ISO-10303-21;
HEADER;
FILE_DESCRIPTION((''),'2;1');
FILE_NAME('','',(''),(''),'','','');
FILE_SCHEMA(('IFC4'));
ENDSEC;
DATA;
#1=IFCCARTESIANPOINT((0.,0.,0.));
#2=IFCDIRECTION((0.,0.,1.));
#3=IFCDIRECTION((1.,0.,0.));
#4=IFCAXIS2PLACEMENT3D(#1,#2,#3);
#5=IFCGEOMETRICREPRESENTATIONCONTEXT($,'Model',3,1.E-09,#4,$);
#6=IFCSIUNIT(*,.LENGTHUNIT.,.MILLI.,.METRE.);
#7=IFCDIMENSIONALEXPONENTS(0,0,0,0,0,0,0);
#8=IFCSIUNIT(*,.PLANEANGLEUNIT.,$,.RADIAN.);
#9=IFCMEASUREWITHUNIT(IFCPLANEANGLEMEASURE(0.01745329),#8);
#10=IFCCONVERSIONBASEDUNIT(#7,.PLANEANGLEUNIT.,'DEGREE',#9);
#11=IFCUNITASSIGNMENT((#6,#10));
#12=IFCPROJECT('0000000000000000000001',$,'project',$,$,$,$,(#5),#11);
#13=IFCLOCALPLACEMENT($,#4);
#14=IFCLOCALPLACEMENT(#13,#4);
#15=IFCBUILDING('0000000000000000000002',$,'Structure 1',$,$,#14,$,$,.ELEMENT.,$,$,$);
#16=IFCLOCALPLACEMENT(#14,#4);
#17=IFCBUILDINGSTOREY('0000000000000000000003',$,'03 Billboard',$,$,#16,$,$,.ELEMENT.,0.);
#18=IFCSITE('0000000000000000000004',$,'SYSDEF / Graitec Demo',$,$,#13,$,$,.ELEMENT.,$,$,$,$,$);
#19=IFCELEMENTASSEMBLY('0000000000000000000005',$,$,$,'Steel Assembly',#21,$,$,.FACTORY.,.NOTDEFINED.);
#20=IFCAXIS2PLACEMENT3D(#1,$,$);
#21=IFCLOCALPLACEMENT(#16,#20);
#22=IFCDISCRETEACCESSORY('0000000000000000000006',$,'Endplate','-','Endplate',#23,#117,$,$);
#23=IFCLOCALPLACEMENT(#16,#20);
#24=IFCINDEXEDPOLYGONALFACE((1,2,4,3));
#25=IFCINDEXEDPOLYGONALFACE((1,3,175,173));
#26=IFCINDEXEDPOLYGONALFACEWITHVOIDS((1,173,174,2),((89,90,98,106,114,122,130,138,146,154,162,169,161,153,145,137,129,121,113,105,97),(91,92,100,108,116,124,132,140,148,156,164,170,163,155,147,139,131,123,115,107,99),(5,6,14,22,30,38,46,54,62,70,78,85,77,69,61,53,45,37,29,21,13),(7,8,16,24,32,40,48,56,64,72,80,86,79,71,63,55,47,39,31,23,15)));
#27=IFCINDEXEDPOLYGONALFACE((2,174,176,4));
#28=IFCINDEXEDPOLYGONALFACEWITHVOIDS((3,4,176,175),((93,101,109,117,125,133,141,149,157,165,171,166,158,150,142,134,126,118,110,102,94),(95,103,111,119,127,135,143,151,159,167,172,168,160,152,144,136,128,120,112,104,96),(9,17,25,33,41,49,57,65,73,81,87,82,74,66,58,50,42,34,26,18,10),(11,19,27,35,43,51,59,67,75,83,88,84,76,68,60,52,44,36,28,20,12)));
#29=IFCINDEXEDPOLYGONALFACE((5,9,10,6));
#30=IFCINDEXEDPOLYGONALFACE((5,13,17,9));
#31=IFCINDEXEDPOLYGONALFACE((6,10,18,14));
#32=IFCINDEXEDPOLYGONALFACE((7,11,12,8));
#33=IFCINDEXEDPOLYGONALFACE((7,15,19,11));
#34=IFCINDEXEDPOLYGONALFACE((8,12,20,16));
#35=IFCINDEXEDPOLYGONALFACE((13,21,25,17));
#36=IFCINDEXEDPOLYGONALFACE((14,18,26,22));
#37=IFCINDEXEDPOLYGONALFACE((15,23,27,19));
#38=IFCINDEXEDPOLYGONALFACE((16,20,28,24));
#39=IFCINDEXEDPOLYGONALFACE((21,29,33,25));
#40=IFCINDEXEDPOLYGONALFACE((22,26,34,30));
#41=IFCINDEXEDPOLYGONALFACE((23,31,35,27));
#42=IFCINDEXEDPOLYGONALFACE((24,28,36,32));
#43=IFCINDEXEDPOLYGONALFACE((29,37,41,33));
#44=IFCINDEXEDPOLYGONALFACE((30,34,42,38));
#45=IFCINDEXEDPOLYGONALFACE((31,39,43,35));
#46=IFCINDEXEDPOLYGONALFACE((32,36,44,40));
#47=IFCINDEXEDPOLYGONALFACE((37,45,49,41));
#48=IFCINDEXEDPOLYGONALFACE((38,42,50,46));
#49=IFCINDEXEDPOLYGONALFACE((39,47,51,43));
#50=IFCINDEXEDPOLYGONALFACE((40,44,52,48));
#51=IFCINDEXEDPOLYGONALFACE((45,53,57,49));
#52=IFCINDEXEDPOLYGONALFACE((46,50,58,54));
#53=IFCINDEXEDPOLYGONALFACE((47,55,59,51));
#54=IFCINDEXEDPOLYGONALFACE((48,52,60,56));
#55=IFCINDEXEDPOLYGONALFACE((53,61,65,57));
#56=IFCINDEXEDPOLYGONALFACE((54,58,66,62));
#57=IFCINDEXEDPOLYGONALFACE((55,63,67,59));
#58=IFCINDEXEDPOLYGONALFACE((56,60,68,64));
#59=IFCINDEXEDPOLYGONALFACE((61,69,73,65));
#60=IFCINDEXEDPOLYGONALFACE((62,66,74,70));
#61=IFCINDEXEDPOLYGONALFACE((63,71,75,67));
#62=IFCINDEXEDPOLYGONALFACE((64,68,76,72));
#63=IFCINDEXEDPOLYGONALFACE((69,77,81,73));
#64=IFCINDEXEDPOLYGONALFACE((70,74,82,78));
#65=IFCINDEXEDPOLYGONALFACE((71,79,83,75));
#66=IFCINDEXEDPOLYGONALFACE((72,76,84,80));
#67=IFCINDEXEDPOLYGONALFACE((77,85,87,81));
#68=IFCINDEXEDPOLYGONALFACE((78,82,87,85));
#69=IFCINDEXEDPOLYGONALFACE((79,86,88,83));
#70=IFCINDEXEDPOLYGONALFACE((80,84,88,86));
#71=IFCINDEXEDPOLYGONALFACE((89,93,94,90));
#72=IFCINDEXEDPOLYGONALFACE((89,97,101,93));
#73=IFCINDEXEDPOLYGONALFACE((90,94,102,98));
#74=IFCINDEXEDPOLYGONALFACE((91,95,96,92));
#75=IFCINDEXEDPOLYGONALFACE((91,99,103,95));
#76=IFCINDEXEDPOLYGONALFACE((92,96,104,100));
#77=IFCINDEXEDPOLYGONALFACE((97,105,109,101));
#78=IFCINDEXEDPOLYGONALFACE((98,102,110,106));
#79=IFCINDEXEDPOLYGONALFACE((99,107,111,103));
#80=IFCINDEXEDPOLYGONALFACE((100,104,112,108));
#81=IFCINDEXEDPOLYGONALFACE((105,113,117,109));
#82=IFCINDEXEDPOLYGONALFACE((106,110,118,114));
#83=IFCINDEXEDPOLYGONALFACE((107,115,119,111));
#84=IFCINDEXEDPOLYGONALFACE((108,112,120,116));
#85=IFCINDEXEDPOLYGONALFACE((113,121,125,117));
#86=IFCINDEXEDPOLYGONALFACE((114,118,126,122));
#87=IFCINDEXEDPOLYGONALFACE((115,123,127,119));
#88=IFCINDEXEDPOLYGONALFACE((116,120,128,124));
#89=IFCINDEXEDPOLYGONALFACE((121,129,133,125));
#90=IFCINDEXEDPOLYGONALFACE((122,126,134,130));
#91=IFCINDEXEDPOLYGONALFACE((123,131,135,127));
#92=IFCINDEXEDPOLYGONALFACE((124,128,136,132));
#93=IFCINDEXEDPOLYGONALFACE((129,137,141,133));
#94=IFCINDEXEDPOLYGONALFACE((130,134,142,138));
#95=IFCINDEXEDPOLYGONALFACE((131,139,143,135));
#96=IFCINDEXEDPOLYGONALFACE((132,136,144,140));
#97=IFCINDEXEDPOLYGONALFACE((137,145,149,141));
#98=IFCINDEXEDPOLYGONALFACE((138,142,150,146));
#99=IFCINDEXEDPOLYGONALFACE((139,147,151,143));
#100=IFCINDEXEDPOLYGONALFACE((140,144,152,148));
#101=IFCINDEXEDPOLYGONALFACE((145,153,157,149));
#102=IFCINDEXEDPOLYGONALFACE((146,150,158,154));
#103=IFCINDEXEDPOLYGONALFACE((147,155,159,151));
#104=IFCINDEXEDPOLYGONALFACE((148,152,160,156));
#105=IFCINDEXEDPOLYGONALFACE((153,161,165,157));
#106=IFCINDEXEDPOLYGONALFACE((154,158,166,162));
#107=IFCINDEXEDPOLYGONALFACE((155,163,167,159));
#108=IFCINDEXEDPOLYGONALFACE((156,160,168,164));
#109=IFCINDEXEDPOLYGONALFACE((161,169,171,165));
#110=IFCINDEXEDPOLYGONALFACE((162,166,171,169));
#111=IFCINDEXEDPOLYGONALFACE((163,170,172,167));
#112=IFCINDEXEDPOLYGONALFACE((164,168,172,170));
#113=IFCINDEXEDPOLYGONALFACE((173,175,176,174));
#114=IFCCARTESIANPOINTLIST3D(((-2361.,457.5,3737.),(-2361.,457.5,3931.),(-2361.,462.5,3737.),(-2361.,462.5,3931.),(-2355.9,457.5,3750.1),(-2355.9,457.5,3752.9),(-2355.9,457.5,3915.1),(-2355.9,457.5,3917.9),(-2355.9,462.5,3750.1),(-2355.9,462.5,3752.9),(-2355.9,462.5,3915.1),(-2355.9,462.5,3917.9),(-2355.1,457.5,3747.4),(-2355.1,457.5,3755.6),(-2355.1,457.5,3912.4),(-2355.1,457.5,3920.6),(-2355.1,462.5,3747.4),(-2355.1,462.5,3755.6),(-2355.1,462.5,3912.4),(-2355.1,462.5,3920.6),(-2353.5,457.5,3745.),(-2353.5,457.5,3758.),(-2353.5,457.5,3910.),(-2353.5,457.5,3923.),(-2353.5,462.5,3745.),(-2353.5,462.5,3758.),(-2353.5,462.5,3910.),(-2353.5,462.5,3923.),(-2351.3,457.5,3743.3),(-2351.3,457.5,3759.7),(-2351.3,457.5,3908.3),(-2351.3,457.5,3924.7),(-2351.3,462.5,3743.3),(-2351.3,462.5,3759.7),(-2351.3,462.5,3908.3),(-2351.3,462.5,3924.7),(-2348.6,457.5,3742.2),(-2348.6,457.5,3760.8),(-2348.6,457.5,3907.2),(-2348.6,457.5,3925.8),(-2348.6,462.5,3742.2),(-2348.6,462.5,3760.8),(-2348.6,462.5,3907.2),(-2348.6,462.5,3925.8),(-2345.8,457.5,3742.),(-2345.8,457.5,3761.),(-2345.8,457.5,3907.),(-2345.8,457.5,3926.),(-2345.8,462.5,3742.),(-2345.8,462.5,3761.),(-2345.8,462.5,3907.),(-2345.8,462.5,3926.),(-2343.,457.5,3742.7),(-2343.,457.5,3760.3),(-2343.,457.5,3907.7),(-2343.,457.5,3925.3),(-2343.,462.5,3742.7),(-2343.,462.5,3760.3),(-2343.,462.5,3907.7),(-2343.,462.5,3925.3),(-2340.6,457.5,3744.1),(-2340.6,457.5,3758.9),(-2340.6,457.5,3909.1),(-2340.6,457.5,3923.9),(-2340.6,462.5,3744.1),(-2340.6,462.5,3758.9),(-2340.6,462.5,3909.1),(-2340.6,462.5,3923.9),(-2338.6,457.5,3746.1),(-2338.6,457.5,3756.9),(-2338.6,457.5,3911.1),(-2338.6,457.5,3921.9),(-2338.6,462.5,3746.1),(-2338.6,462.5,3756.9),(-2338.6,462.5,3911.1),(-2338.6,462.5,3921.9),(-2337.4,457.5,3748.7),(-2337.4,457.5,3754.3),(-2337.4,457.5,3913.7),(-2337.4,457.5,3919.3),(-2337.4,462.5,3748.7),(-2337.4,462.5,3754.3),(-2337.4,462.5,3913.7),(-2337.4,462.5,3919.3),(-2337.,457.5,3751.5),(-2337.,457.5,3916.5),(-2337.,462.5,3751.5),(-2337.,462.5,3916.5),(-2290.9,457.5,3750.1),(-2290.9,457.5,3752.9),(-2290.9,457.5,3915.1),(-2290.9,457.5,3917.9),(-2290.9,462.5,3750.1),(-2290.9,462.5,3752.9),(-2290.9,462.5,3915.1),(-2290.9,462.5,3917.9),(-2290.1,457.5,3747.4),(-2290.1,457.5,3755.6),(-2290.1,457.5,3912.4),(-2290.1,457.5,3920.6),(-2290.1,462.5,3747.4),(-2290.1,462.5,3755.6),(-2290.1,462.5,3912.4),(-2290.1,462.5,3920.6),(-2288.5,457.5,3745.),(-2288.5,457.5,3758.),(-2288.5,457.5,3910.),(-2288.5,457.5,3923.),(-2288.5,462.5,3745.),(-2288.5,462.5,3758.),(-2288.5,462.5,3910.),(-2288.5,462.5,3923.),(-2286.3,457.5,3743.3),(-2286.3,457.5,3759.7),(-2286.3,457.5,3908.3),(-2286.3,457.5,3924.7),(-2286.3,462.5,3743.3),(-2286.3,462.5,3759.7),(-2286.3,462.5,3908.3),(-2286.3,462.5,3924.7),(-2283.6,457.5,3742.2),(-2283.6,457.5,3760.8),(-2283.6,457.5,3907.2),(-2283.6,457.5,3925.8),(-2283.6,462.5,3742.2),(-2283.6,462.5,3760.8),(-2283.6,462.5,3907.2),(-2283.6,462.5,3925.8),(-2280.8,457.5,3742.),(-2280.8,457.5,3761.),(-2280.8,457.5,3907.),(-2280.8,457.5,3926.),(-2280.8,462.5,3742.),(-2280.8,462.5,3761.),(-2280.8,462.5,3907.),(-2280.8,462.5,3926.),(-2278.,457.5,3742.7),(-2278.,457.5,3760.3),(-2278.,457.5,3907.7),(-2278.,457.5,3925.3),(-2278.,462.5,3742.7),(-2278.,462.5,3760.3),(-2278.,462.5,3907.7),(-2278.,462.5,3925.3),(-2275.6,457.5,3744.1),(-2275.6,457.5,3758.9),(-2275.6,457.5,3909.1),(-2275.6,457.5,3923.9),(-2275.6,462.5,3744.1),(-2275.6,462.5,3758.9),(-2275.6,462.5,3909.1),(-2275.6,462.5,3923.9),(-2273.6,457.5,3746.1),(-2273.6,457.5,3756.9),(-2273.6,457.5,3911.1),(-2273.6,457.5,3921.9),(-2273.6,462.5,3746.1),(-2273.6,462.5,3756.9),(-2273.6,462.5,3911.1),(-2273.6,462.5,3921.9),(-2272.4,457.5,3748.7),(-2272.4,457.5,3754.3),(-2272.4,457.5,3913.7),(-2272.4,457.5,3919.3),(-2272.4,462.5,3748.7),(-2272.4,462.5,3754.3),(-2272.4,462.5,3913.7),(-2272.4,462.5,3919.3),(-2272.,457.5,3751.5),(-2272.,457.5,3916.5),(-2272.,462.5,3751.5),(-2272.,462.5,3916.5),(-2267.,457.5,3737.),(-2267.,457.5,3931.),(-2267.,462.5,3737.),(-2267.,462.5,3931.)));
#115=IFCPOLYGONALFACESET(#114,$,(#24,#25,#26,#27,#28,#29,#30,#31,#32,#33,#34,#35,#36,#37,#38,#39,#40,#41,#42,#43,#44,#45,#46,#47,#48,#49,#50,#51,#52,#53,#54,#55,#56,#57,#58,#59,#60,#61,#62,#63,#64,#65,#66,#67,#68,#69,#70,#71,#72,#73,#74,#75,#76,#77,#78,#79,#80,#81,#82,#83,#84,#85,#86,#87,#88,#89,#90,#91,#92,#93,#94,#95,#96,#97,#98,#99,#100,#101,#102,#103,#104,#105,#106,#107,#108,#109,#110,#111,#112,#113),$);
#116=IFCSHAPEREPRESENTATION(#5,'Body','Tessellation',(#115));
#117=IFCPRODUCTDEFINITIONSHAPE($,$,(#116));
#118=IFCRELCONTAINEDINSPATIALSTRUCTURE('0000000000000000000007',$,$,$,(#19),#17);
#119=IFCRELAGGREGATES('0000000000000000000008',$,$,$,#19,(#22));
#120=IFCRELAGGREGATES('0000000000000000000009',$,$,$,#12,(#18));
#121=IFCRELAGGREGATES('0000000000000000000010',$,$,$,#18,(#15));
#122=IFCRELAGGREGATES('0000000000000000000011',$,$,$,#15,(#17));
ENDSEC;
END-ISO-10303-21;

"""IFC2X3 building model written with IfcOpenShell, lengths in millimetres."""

from ifc_helpers import new_model, entity, si_unit, converted_unit, frame, frame_2d, origin, origin_with_axes, place, context, project, spatial, polyline, circle, outline, extrude, element, aggregate, save


model = new_model("IFC2X3")

# Units and contexts
model_context = context("Model", 3, precision=1e-09, world=origin_with_axes())
ifc_project = project(units=[si_unit("LENGTHUNIT", "METRE", prefix="MILLI"), converted_unit("PLANEANGLEUNIT", "DEGREE", entity("IfcPlaneAngleMeasure", 0.01745329), si_unit("PLANEANGLEUNIT", "RADIAN"), dimensions=[0, 0, 0, 0, 0, 0, 0])], contexts=[model_context])

# Site, building, storey
site_placement = place(None, origin_with_axes())
site = spatial("IfcSite", under=ifc_project, at=site_placement, Name="SYSDEF / Graitec Demo", CompositionType="ELEMENT")
building_placement = place(site_placement, origin_with_axes())
building = spatial("IfcBuilding", under=site, at=building_placement, Name="Structure 1", CompositionType="ELEMENT")
storey_placement = place(building_placement, origin_with_axes())
storey = spatial("IfcBuildingStorey", under=building, at=storey_placement, Name="03 Billboard", CompositionType="ELEMENT", Elevation=0.0)

# Element assembly
assembly_1_placement = place(None, frame((-4406.3, 0.0, 3558.0), z_axis=(-1.0, 0.0, 0.0), x_axis=(0.0, -1.0, 0.0)))
assembly_1 = element("IfcElementAssembly", 1, at=assembly_1_placement, inside=storey, ObjectType="Steel Assembly", AssemblyPlace="FACTORY", PredefinedType="NOTDEFINED")

# Discrete accessory, openings
discrete_accessory_1_placement = place(assembly_1_placement, frame((-457.5, 373.0, -2045.3), z_axis=(-1.0, 0.0, 0.0), x_axis=(0.0, 0.0, -1.0)))
discrete_accessory_1 = element("IfcDiscreteAccessory", 2, at=discrete_accessory_1_placement, Name="Endplate", Description="-", ObjectType="Endplate", context=model_context, shape_type="SweptSolid", body=[
    extrude(outline(polyline([(0.0, 0.0), (94.0, 0.0), (94.0, 194.0), (0.0, 194.0), (0.0, 0.0)])), origin_with_axes(), (0.0, 0.0, 1.0), 5.0),
])
opening_1_placement = place(discrete_accessory_1_placement, frame((47.0, 97.0, 5.5), z_axis=(0.0, 0.0, -1.0), x_axis=(1.0, 0.0, 0.0)))
element("IfcOpeningElement", 3, at=opening_1_placement, cuts=discrete_accessory_1, ObjectType="Opening", context=model_context, shape_type="SweptSolid", body=[
    extrude(circle(Radius=9.5, at=frame_2d((32.5, 82.5), x_axis=(1.0, 0.0))), origin(), (0.0, 0.0, 1.0), 6.0),
])
opening_2_placement = place(discrete_accessory_1_placement, frame((47.0, 97.0, 5.5), z_axis=(0.0, 0.0, -1.0), x_axis=(1.0, 0.0, 0.0)))
element("IfcOpeningElement", 4, at=opening_2_placement, cuts=discrete_accessory_1, ObjectType="Opening", context=model_context, shape_type="SweptSolid", body=[
    extrude(circle(Radius=9.5, at=frame_2d((-32.5, 82.5), x_axis=(1.0, 0.0))), origin(), (0.0, 0.0, 1.0), 6.0),
])
opening_3_placement = place(discrete_accessory_1_placement, frame((47.0, 97.0, 5.5), z_axis=(0.0, 0.0, -1.0), x_axis=(1.0, 0.0, 0.0)))
element("IfcOpeningElement", 5, at=opening_3_placement, cuts=discrete_accessory_1, ObjectType="Opening", context=model_context, shape_type="SweptSolid", body=[
    extrude(circle(Radius=9.5, at=frame_2d((32.5, -82.5), x_axis=(1.0, 0.0))), origin(), (0.0, 0.0, 1.0), 6.0),
])
opening_4_placement = place(discrete_accessory_1_placement, frame((47.0, 97.0, 5.5), z_axis=(0.0, 0.0, -1.0), x_axis=(1.0, 0.0, 0.0)))
element("IfcOpeningElement", 6, at=opening_4_placement, cuts=discrete_accessory_1, ObjectType="Opening", context=model_context, shape_type="SweptSolid", body=[
    extrude(circle(Radius=9.5, at=frame_2d((-32.5, -82.5), x_axis=(1.0, 0.0))), origin(), (0.0, 0.0, 1.0), 6.0),
])
aggregate(assembly_1, [discrete_accessory_1])

save(model, "model.ifc")
